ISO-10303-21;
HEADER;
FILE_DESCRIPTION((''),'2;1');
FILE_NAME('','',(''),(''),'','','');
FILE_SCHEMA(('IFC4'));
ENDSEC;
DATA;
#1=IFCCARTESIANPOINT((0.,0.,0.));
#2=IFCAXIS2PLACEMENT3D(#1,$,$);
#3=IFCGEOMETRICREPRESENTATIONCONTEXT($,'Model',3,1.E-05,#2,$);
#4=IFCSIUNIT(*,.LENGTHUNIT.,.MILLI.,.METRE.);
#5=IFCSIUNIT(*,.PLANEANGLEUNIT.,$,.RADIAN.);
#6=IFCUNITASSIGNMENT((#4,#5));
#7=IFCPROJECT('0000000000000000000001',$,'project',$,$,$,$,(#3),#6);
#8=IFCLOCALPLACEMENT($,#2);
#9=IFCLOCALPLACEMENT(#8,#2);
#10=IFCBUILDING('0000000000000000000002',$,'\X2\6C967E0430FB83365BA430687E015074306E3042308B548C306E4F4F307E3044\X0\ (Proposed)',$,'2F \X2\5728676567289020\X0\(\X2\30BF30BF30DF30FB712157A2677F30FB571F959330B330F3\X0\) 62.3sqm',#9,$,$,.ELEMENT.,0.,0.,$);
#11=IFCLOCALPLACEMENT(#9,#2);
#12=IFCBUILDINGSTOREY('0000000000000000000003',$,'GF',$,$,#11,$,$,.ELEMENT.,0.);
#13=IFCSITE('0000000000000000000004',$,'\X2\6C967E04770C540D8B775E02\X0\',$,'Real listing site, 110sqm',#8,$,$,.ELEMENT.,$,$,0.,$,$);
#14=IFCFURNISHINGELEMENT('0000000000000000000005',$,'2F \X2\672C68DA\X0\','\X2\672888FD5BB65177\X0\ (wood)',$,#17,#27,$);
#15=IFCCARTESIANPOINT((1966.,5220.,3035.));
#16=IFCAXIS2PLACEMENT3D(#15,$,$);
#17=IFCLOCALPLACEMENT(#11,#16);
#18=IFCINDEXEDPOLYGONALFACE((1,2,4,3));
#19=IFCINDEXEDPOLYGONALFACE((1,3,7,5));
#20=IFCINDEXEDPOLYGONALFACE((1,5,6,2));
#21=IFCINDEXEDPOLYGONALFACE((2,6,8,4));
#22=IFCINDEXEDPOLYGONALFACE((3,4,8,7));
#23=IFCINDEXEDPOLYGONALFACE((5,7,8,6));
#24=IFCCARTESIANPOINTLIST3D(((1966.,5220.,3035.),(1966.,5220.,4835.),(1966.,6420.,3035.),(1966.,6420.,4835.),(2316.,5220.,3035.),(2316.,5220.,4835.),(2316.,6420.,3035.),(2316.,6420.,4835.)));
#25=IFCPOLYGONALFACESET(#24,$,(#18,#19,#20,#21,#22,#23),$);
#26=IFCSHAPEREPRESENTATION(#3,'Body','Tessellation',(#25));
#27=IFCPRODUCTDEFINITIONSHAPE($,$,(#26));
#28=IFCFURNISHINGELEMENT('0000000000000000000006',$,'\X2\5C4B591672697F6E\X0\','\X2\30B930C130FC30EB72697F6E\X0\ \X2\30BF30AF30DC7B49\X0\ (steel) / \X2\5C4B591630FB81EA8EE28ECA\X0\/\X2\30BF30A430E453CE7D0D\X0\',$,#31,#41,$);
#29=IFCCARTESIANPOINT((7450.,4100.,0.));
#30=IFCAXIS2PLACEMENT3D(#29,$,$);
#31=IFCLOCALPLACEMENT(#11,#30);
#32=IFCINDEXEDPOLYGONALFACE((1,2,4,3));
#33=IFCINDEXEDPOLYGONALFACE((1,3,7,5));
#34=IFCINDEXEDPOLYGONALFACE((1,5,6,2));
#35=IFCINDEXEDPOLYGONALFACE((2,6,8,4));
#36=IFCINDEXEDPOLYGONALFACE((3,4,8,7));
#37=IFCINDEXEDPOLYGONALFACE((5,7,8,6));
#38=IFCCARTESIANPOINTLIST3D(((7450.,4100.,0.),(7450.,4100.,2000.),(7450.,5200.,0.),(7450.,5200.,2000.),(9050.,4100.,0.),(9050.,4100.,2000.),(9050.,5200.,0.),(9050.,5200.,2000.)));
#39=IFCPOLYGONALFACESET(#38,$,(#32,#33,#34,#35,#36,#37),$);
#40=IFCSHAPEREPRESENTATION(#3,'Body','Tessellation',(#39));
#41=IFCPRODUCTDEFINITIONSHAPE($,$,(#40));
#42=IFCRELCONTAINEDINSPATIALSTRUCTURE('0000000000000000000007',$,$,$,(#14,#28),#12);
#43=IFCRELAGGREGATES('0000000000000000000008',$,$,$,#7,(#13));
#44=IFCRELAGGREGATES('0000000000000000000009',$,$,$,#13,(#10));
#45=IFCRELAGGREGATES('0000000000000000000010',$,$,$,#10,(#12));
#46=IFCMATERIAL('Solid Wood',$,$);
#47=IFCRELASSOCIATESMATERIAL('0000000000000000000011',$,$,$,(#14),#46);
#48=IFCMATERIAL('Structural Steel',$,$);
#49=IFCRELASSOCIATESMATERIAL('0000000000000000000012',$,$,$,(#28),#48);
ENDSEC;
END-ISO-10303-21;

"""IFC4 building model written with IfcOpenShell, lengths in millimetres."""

from ifc_helpers import new_model, si_unit, frame, frame_2d, origin, place, context, project, spatial, rectangle, extrude, material, element, save


model = new_model("IFC4")

# Units and contexts
model_context = context("Model", 3, precision=1e-05, world=origin())
ifc_project = project(units=[si_unit("LENGTHUNIT", "METRE", prefix="MILLI"), si_unit("PLANEANGLEUNIT", "RADIAN")], contexts=[model_context])

# Site, building, storey
site_placement = place(None, origin())
site = spatial("IfcSite", under=ifc_project, at=site_placement, Name="沖縄県名護市", ObjectType="Real listing site, 110sqm", CompositionType="ELEMENT", RefElevation=0.0)
building_placement = place(site_placement, origin())
building = spatial("IfcBuilding", under=site, at=building_placement, Name="沖縄・茶室と縁側のある和の住まい (Proposed)", ObjectType="2F 在来木造(タタミ・無垢板・土間コン) 62.3sqm", CompositionType="ELEMENT", ElevationOfRefHeight=0.0, ElevationOfTerrain=0.0)
storey_placement = place(building_placement, origin())
storey = spatial("IfcBuildingStorey", under=building, at=storey_placement, Name="GF", CompositionType="ELEMENT", Elevation=0.0)

# Shared definitions
ifc_material_1 = material(Name="Solid Wood")

# Shared definitions
ifc_material_2 = material(Name="Structural Steel")

# Furnishing elements
furnishing_1_placement = place(storey_placement, frame((1966.0, 5220.0, 3035.0)))
element("IfcFurnishingElement", 1, at=furnishing_1_placement, inside=storey, material=ifc_material_1, Name="2F 本棚", Description="木製家具 (wood)", context=model_context, shape_type="SweptSolid", body=[
    extrude(rectangle(XDim=350.0, YDim=1200.0, at=frame_2d((175.0, 600.0))), frame((1966.0, 5220.0, 3035.0)), (0.0, 0.0, 1.0), 1800.0),
])
furnishing_2_placement = place(storey_placement, frame((7450.0, 4100.0, 0.0)))
element("IfcFurnishingElement", 2, at=furnishing_2_placement, inside=storey, material=ifc_material_2, Name="屋外物置", Description="スチール物置 タクボ等 (steel) / 屋外・自転車/タイヤ収納", context=model_context, shape_type="SweptSolid", body=[
    extrude(rectangle(XDim=1600.0, YDim=1100.0, at=frame_2d((800.0, 550.0))), frame((7450.0, 4100.0, 0.0)), (0.0, 0.0, 1.0), 2000.0),
])

save(model, "model.ifc")
